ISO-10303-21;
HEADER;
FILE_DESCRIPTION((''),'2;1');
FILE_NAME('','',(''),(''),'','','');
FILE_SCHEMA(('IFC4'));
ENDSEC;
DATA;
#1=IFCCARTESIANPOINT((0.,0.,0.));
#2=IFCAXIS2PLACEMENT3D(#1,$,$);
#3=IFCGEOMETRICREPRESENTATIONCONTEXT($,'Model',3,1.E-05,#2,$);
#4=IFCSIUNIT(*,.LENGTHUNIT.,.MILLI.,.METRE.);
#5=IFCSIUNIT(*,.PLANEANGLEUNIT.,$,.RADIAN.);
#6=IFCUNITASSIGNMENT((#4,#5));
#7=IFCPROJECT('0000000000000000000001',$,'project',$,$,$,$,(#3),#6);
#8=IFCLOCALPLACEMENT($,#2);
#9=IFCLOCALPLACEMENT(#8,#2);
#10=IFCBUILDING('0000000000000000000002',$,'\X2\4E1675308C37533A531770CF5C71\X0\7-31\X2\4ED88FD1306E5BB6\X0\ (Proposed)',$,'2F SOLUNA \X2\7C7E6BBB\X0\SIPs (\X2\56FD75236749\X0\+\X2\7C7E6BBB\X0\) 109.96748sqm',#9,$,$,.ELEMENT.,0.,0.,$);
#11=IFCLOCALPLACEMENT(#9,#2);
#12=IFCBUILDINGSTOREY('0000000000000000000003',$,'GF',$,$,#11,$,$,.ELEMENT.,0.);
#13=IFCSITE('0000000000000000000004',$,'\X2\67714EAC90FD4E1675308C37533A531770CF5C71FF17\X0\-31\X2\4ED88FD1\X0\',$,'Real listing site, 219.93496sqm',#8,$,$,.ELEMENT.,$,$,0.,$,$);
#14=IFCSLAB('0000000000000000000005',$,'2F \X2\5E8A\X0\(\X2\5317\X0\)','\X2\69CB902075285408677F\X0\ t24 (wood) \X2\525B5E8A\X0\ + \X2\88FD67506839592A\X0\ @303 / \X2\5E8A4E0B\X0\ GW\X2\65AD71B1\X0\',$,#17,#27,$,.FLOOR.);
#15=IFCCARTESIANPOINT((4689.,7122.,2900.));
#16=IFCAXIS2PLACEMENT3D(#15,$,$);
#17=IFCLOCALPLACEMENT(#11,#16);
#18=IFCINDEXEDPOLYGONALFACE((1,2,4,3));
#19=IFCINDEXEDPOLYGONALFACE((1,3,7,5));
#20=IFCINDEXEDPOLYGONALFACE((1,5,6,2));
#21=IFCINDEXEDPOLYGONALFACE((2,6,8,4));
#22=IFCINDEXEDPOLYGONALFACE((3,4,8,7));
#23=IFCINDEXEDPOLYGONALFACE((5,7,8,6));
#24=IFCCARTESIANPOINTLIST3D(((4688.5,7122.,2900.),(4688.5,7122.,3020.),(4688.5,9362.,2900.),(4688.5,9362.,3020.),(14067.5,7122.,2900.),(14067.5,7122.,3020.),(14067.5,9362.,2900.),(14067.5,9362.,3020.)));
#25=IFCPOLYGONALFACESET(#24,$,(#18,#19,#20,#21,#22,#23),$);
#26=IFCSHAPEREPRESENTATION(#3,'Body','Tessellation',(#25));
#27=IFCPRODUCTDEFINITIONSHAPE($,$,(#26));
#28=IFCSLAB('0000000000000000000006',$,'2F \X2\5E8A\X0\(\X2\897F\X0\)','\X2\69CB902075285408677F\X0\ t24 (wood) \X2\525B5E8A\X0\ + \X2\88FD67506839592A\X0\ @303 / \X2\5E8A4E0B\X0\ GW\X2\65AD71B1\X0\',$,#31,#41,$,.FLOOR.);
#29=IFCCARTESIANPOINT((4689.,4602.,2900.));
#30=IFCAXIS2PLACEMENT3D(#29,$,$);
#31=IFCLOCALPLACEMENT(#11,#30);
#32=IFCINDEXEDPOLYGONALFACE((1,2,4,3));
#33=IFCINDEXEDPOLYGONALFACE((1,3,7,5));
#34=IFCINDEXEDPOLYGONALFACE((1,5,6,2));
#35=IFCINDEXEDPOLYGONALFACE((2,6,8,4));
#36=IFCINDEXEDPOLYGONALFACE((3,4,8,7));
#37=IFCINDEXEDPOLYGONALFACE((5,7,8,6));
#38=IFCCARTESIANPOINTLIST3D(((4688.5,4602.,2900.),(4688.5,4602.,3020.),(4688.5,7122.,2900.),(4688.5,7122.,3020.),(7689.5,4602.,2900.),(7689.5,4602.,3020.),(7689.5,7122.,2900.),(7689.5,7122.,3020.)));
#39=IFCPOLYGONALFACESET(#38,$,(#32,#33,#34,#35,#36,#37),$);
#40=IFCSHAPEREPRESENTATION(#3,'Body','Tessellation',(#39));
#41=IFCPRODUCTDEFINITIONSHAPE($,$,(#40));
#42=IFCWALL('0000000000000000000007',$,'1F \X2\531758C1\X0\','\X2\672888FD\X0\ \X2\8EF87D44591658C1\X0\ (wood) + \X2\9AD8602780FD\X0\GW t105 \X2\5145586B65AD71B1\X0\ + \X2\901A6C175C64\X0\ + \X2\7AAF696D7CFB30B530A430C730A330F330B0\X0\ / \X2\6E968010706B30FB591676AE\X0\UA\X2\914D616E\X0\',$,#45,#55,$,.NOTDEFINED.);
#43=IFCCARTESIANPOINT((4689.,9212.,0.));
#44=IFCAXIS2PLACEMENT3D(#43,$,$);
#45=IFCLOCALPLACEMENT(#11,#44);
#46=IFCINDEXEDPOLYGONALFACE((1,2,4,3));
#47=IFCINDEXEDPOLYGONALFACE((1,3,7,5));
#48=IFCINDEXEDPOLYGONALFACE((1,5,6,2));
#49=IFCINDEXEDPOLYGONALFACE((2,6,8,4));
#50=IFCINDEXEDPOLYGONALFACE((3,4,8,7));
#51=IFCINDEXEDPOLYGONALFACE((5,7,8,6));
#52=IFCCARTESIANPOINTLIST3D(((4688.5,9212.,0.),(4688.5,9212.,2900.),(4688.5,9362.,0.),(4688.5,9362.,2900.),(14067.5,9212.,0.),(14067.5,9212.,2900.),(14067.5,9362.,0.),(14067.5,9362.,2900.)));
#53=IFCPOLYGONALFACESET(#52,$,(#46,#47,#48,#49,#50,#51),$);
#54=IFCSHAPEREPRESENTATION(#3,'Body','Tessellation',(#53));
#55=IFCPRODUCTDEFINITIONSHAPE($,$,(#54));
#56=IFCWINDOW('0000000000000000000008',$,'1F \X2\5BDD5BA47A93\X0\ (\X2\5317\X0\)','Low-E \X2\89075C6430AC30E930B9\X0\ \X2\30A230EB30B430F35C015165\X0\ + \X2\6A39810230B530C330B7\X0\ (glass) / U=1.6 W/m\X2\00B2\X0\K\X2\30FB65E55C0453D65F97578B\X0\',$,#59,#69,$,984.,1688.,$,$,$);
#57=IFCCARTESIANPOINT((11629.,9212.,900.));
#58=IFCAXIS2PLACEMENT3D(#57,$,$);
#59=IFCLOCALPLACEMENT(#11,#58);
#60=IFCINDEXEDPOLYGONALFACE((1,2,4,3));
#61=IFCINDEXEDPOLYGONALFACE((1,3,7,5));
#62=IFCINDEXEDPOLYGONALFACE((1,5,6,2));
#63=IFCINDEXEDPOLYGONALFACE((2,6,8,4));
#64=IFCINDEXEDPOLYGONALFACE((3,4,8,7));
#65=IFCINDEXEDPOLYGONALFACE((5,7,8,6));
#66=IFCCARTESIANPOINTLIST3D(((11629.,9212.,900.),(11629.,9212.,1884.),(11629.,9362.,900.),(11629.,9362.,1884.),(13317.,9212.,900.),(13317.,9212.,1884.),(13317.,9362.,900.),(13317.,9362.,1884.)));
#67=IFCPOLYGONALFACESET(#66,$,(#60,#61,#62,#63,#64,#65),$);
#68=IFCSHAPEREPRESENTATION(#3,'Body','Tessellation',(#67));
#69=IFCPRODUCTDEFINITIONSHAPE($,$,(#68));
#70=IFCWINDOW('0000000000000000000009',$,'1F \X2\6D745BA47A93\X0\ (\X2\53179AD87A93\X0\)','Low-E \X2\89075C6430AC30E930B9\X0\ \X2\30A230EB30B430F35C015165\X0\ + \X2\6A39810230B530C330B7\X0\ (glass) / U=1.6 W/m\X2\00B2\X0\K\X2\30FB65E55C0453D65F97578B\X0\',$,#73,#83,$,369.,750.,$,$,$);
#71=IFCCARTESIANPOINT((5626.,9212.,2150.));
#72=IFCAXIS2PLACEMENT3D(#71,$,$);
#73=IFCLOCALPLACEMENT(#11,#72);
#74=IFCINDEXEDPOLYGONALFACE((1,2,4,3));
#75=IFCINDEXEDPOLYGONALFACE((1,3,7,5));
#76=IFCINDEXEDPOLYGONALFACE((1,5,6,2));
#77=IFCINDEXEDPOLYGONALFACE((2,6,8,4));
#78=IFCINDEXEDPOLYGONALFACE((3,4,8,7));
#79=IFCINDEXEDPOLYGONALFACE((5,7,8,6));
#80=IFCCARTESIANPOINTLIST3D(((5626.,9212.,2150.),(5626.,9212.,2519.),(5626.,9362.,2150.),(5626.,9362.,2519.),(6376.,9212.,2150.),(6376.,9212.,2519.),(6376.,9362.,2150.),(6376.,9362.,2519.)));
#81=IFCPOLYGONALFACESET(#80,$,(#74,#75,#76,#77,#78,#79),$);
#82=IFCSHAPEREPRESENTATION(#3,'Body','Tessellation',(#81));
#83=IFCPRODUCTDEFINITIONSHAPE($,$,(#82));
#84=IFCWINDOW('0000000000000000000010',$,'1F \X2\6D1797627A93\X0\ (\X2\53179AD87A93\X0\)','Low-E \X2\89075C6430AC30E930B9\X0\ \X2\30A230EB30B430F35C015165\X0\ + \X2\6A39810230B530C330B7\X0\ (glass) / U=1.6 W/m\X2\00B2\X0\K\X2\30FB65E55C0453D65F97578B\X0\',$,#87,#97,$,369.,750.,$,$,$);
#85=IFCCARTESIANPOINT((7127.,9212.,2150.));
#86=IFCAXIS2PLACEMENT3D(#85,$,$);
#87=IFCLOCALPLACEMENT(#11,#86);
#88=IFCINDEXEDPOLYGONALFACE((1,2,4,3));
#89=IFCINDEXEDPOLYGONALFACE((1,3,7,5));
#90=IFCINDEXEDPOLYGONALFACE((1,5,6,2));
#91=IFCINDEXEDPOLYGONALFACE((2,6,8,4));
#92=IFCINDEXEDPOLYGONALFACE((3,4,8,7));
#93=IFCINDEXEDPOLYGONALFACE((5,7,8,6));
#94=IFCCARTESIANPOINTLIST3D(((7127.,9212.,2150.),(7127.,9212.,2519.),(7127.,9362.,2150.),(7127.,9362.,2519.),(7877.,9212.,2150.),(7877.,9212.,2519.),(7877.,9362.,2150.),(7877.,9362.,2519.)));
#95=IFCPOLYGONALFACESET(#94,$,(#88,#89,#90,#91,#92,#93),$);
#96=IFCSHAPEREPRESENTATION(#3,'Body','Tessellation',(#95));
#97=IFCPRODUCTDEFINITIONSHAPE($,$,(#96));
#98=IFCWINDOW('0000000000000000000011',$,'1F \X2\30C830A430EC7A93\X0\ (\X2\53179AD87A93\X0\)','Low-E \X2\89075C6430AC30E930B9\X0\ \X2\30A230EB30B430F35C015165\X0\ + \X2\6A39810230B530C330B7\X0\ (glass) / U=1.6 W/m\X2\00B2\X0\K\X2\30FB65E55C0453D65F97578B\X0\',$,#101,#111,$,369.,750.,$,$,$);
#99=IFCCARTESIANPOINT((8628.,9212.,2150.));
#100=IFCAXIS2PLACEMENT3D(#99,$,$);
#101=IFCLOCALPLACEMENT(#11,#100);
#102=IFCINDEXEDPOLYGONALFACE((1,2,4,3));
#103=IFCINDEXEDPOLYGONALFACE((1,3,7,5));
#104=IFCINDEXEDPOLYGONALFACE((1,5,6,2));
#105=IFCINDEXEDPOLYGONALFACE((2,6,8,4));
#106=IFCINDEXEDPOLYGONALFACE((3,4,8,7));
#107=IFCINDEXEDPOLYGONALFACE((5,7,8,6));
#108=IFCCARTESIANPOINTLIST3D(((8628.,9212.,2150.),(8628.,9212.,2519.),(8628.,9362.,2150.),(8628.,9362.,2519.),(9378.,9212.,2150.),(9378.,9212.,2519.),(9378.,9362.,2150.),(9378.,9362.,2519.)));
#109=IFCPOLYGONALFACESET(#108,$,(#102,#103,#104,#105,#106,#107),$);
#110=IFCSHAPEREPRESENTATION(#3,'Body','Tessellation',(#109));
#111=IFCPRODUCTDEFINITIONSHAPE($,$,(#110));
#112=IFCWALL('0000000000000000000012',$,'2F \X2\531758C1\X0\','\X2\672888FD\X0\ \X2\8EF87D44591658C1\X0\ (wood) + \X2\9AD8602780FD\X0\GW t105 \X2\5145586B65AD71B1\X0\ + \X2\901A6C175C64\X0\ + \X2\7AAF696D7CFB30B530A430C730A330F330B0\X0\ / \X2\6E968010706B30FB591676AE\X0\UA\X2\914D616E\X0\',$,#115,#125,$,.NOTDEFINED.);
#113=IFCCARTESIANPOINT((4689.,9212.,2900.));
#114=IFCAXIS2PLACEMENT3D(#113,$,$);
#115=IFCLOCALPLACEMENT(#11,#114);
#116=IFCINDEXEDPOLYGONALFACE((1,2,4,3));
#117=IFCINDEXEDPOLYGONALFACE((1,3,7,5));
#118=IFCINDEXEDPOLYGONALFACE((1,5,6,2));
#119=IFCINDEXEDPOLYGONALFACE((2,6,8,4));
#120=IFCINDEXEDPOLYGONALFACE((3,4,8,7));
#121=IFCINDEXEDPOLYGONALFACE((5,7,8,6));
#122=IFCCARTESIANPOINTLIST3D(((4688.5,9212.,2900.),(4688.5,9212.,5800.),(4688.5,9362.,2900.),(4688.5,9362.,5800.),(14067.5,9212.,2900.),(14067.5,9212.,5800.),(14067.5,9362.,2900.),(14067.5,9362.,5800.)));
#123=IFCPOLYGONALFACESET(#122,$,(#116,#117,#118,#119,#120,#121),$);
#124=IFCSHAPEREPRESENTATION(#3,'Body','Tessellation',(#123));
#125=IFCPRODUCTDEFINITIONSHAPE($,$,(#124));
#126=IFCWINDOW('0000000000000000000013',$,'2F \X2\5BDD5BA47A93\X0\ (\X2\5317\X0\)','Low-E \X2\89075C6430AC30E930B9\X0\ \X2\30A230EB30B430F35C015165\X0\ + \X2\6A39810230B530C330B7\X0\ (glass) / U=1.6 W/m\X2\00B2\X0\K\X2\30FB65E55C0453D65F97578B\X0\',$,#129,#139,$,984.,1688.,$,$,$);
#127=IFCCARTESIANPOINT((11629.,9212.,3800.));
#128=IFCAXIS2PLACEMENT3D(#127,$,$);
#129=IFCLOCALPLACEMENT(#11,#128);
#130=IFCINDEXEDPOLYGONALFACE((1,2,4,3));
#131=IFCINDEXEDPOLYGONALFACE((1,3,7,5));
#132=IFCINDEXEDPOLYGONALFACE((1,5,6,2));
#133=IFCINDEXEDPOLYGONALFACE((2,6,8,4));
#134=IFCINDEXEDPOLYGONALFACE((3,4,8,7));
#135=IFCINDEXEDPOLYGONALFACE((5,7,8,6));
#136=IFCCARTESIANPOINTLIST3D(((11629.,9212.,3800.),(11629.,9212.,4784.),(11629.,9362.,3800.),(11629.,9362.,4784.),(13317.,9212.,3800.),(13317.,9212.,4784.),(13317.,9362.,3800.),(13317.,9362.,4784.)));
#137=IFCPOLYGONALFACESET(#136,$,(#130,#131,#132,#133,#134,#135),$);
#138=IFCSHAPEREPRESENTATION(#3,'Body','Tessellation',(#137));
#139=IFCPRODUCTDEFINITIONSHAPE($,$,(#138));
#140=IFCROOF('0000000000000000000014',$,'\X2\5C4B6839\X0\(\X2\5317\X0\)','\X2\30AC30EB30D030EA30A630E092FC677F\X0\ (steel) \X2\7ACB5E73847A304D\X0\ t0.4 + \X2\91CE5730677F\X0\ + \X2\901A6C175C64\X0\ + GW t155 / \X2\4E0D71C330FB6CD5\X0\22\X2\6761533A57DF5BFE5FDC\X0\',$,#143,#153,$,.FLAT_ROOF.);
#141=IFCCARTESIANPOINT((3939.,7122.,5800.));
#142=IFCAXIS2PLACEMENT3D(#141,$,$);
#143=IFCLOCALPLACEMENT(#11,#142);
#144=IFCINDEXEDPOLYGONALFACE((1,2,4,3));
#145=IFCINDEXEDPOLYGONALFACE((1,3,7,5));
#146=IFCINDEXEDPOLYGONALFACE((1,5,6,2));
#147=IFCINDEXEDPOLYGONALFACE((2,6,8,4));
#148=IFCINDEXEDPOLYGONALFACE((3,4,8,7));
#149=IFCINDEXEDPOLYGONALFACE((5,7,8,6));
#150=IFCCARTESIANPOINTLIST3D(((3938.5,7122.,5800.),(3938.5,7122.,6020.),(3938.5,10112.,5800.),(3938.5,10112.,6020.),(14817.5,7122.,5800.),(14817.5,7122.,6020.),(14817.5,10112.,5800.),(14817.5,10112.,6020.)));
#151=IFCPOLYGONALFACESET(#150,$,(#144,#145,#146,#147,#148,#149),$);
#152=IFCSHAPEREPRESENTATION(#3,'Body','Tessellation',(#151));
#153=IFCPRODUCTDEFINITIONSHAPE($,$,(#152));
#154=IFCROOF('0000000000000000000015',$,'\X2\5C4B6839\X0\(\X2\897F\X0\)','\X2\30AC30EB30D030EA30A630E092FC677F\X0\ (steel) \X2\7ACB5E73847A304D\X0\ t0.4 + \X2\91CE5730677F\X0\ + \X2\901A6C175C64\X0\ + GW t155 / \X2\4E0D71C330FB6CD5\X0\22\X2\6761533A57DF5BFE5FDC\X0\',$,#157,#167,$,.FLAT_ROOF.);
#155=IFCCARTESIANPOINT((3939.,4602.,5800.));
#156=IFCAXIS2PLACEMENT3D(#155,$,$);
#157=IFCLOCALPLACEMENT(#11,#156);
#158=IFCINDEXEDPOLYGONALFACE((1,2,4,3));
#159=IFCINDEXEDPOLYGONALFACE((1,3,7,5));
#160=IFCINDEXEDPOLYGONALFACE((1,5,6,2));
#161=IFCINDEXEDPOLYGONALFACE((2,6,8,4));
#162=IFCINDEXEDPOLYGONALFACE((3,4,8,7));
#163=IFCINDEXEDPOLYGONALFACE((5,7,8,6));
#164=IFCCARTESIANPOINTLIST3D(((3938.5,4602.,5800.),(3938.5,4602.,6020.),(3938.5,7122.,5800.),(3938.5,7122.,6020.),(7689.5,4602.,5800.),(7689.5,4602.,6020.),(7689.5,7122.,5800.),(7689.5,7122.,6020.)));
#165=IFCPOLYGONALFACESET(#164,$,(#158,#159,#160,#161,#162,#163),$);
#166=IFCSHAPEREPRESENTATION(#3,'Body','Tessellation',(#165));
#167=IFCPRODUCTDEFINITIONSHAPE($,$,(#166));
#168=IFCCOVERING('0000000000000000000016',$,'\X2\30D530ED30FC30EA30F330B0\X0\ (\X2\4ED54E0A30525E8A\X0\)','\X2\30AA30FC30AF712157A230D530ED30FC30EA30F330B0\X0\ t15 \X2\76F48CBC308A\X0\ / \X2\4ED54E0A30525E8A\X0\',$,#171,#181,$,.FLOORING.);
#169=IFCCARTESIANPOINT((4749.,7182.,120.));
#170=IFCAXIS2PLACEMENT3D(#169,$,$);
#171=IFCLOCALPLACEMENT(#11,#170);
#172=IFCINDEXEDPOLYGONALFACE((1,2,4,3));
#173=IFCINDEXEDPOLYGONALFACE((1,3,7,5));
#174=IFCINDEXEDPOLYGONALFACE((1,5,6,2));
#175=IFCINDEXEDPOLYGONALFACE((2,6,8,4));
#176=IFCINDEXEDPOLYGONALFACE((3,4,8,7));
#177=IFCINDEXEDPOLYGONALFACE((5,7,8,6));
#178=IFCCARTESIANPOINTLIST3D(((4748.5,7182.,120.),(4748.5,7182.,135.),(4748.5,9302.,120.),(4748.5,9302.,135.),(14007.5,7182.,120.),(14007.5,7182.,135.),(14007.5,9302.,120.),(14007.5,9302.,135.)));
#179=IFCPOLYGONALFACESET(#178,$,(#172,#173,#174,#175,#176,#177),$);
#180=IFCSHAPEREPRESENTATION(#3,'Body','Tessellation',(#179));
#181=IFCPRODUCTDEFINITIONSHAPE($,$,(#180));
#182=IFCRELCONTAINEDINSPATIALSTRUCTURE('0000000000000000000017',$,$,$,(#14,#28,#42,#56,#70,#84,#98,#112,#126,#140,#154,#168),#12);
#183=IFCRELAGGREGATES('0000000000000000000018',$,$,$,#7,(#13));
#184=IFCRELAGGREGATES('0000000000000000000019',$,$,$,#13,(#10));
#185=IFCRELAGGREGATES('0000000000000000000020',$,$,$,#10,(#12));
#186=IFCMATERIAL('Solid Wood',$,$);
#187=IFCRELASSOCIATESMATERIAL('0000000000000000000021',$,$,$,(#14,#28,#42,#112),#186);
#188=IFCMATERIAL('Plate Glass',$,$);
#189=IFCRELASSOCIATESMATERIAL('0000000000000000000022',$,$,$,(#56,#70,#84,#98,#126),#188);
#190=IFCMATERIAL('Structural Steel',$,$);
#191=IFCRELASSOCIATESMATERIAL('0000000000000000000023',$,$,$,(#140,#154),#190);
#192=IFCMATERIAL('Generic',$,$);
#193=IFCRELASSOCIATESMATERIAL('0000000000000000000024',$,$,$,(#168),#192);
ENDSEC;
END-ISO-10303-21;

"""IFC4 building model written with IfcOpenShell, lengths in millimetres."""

from ifc_helpers import new_model, si_unit, frame, frame_2d, origin, place, context, project, spatial, rectangle, extrude, material, element, fill, save


model = new_model("IFC4")

# Units and contexts
model_context = context("Model", 3, precision=1e-05, world=origin())
ifc_project = project(units=[si_unit("LENGTHUNIT", "METRE", prefix="MILLI"), si_unit("PLANEANGLEUNIT", "RADIAN")], contexts=[model_context])

# Site, building, storey
site_placement = place(None, origin())
site = spatial("IfcSite", under=ifc_project, at=site_placement, Name="東京都世田谷区北烏山７-31付近", ObjectType="Real listing site, 219.93496sqm", CompositionType="ELEMENT", RefElevation=0.0)
building_placement = place(site_placement, origin())
building = spatial("IfcBuilding", under=site, at=building_placement, Name="世田谷区北烏山7-31付近の家 (Proposed)", ObjectType="2F SOLUNA 籾殻SIPs (国産杉+籾殻) 109.96748sqm", CompositionType="ELEMENT", ElevationOfRefHeight=0.0, ElevationOfTerrain=0.0)
storey_placement = place(building_placement, origin())
storey = spatial("IfcBuildingStorey", under=building, at=storey_placement, Name="GF", CompositionType="ELEMENT", Elevation=0.0)

# Slabs
ifc_material_1 = material(Name="Solid Wood")
slab_1_placement = place(storey_placement, frame((4689.0, 7122.0, 2900.0)))
element("IfcSlab", 1, at=slab_1_placement, inside=storey, material=ifc_material_1, Name="2F 床(北)", Description="構造用合板 t24 (wood) 剛床 + 製材根太 @303 / 床下 GW断熱", PredefinedType="FLOOR", context=model_context, shape_type="SweptSolid", body=[
    extrude(rectangle(XDim=9379.0, YDim=2240.0, at=frame_2d((4689.0, 1120.0))), frame((4689.0, 7122.0, 2900.0)), (0.0, 0.0, 1.0), 120.0),
])
slab_2_placement = place(storey_placement, frame((4689.0, 4602.0, 2900.0)))
element("IfcSlab", 2, at=slab_2_placement, inside=storey, material=ifc_material_1, Name="2F 床(西)", Description="構造用合板 t24 (wood) 剛床 + 製材根太 @303 / 床下 GW断熱", PredefinedType="FLOOR", context=model_context, shape_type="SweptSolid", body=[
    extrude(rectangle(XDim=3001.0, YDim=2520.0, at=frame_2d((1500.0, 1260.0))), frame((4689.0, 4602.0, 2900.0)), (0.0, 0.0, 1.0), 120.0),
])

# Wall, openings, windows
wall_1_placement = place(storey_placement, frame((4689.0, 9212.0, 0.0)))
wall_1 = element("IfcWall", 3, at=wall_1_placement, inside=storey, material=ifc_material_1, Name="1F 北壁", Description="木製 軸組外壁 (wood) + 高性能GW t105 充填断熱 + 通気層 + 窯業系サイディング / 準耐火・外皮UA配慮", PredefinedType="NOTDEFINED", context=model_context, shape_type="SweptSolid", body=[
    extrude(rectangle(XDim=9379.0, YDim=150.0, at=frame_2d((4689.0, 75.0))), frame((4689.0, 9212.0, 0.0)), (0.0, 0.0, 1.0), 2900.0),
])
opening_1_placement = place(storey_placement, frame((11629.0, 9212.0, 900.0)))
opening_1 = element("IfcOpeningElement", 4, at=opening_1_placement, cuts=wall_1, PredefinedType="NOTDEFINED", context=model_context, shape_type="SweptSolid", body=[
    extrude(rectangle(XDim=1688.0, YDim=150.0, at=frame_2d((844.0, 75.0))), frame((11629.0, 9212.0, 900.0)), (0.0, 0.0, 1.0), 984.0),
])
opening_2_placement = place(storey_placement, frame((5626.0, 9212.0, 2150.0)))
opening_2 = element("IfcOpeningElement", 5, at=opening_2_placement, cuts=wall_1, PredefinedType="NOTDEFINED", context=model_context, shape_type="SweptSolid", body=[
    extrude(rectangle(XDim=750.0, YDim=150.0, at=frame_2d((375.0, 75.0))), frame((5626.0, 9212.0, 2150.0)), (0.0, 0.0, 1.0), 369.0),
])
opening_3_placement = place(storey_placement, frame((7127.0, 9212.0, 2150.0)))
opening_3 = element("IfcOpeningElement", 6, at=opening_3_placement, cuts=wall_1, PredefinedType="NOTDEFINED", context=model_context, shape_type="SweptSolid", body=[
    extrude(rectangle(XDim=750.0, YDim=150.0, at=frame_2d((375.0, 75.0))), frame((7127.0, 9212.0, 2150.0)), (0.0, 0.0, 1.0), 369.0),
])
opening_4_placement = place(storey_placement, frame((8628.0, 9212.0, 2150.0)))
opening_4 = element("IfcOpeningElement", 7, at=opening_4_placement, cuts=wall_1, PredefinedType="NOTDEFINED", context=model_context, shape_type="SweptSolid", body=[
    extrude(rectangle(XDim=750.0, YDim=150.0, at=frame_2d((375.0, 75.0))), frame((8628.0, 9212.0, 2150.0)), (0.0, 0.0, 1.0), 369.0),
])
ifc_material_2 = material(Name="Plate Glass")
window_1_placement = place(storey_placement, frame((11629.0, 9212.0, 900.0)))
window_1 = element("IfcWindow", 8, at=window_1_placement, inside=storey, material=ifc_material_2, Name="1F 寝室窓 (北)", Description="Low-E 複層ガラス アルゴン封入 + 樹脂サッシ (glass) / U=1.6 W/m²K・日射取得型", OverallHeight=984.0, OverallWidth=1688.0, context=model_context, shape_type="SweptSolid", body=[
    extrude(rectangle(XDim=1688.0, YDim=150.0, at=frame_2d((844.0, 75.0))), frame((11629.0, 9212.0, 900.0)), (0.0, 0.0, 1.0), 984.0),
])
fill(opening_1, window_1)
window_2_placement = place(storey_placement, frame((5626.0, 9212.0, 2150.0)))
window_2 = element("IfcWindow", 9, at=window_2_placement, inside=storey, material=ifc_material_2, Name="1F 浴室窓 (北高窓)", Description="Low-E 複層ガラス アルゴン封入 + 樹脂サッシ (glass) / U=1.6 W/m²K・日射取得型", OverallHeight=369.0, OverallWidth=750.0, context=model_context, shape_type="SweptSolid", body=[
    extrude(rectangle(XDim=750.0, YDim=150.0, at=frame_2d((375.0, 75.0))), frame((5626.0, 9212.0, 2150.0)), (0.0, 0.0, 1.0), 369.0),
])
fill(opening_2, window_2)
window_3_placement = place(storey_placement, frame((7127.0, 9212.0, 2150.0)))
window_3 = element("IfcWindow", 10, at=window_3_placement, inside=storey, material=ifc_material_2, Name="1F 洗面窓 (北高窓)", Description="Low-E 複層ガラス アルゴン封入 + 樹脂サッシ (glass) / U=1.6 W/m²K・日射取得型", OverallHeight=369.0, OverallWidth=750.0, context=model_context, shape_type="SweptSolid", body=[
    extrude(rectangle(XDim=750.0, YDim=150.0, at=frame_2d((375.0, 75.0))), frame((7127.0, 9212.0, 2150.0)), (0.0, 0.0, 1.0), 369.0),
])
fill(opening_3, window_3)
window_4_placement = place(storey_placement, frame((8628.0, 9212.0, 2150.0)))
window_4 = element("IfcWindow", 11, at=window_4_placement, inside=storey, material=ifc_material_2, Name="1F トイレ窓 (北高窓)", Description="Low-E 複層ガラス アルゴン封入 + 樹脂サッシ (glass) / U=1.6 W/m²K・日射取得型", OverallHeight=369.0, OverallWidth=750.0, context=model_context, shape_type="SweptSolid", body=[
    extrude(rectangle(XDim=750.0, YDim=150.0, at=frame_2d((375.0, 75.0))), frame((8628.0, 9212.0, 2150.0)), (0.0, 0.0, 1.0), 369.0),
])
fill(opening_4, window_4)

# Wall, opening, window
wall_2_placement = place(storey_placement, frame((4689.0, 9212.0, 2900.0)))
wall_2 = element("IfcWall", 12, at=wall_2_placement, inside=storey, material=ifc_material_1, Name="2F 北壁", Description="木製 軸組外壁 (wood) + 高性能GW t105 充填断熱 + 通気層 + 窯業系サイディング / 準耐火・外皮UA配慮", PredefinedType="NOTDEFINED", context=model_context, shape_type="SweptSolid", body=[
    extrude(rectangle(XDim=9379.0, YDim=150.0, at=frame_2d((4689.0, 75.0))), frame((4689.0, 9212.0, 2900.0)), (0.0, 0.0, 1.0), 2900.0),
])
opening_5_placement = place(storey_placement, frame((11629.0, 9212.0, 3800.0)))
opening_5 = element("IfcOpeningElement", 13, at=opening_5_placement, cuts=wall_2, PredefinedType="NOTDEFINED", context=model_context, shape_type="SweptSolid", body=[
    extrude(rectangle(XDim=1688.0, YDim=150.0, at=frame_2d((844.0, 75.0))), frame((11629.0, 9212.0, 3800.0)), (0.0, 0.0, 1.0), 984.0),
])
window_5_placement = place(storey_placement, frame((11629.0, 9212.0, 3800.0)))
window_5 = element("IfcWindow", 14, at=window_5_placement, inside=storey, material=ifc_material_2, Name="2F 寝室窓 (北)", Description="Low-E 複層ガラス アルゴン封入 + 樹脂サッシ (glass) / U=1.6 W/m²K・日射取得型", OverallHeight=984.0, OverallWidth=1688.0, context=model_context, shape_type="SweptSolid", body=[
    extrude(rectangle(XDim=1688.0, YDim=150.0, at=frame_2d((844.0, 75.0))), frame((11629.0, 9212.0, 3800.0)), (0.0, 0.0, 1.0), 984.0),
])
fill(opening_5, window_5)

# Roofs
ifc_material_3 = material(Name="Structural Steel")
for number, where, name in (
    (15, (3939.0, 7122.0, 5800.0), "屋根(北)"),
):
    element("IfcRoof", number, at=place(storey_placement, frame(where)), inside=storey, material=ifc_material_3, Name=name, Description="ガルバリウム鋼板 (steel) 立平葺き t0.4 + 野地板 + 通気層 + GW t155 / 不燃・法22条区域対応", PredefinedType="FLAT_ROOF", context=model_context, shape_type="SweptSolid", body=[
        extrude(rectangle(XDim=10879.0, YDim=2990.0, at=frame_2d((5439.0, 1495.0))), frame((3939.0, 7122.0, 5800.0)), (0.0, 0.0, 1.0), 220.0),
    ])
roof_placement = place(storey_placement, frame((3939.0, 4602.0, 5800.0)))
element("IfcRoof", 16, at=roof_placement, inside=storey, material=ifc_material_3, Name="屋根(西)", Description="ガルバリウム鋼板 (steel) 立平葺き t0.4 + 野地板 + 通気層 + GW t155 / 不燃・法22条区域対応", PredefinedType="FLAT_ROOF", context=model_context, shape_type="SweptSolid", body=[
    extrude(rectangle(XDim=3751.0, YDim=2520.0, at=frame_2d((1875.0, 1260.0))), frame((3939.0, 4602.0, 5800.0)), (0.0, 0.0, 1.0), 220.0),
])

# Covering
ifc_material_4 = material(Name="Generic")
covering_1_placement = place(storey_placement, frame((4749.0, 7182.0, 120.0)))
element("IfcCovering", 17, at=covering_1_placement, inside=storey, material=ifc_material_4, Name="フローリング (仕上げ床)", Description="オーク無垢フローリング t15 直貼り / 仕上げ床", PredefinedType="FLOORING", context=model_context, shape_type="SweptSolid", body=[
    extrude(rectangle(XDim=9259.0, YDim=2120.0, at=frame_2d((4629.0, 1060.0))), frame((4749.0, 7182.0, 120.0)), (0.0, 0.0, 1.0), 15.0),
])

save(model, "model.ifc")
